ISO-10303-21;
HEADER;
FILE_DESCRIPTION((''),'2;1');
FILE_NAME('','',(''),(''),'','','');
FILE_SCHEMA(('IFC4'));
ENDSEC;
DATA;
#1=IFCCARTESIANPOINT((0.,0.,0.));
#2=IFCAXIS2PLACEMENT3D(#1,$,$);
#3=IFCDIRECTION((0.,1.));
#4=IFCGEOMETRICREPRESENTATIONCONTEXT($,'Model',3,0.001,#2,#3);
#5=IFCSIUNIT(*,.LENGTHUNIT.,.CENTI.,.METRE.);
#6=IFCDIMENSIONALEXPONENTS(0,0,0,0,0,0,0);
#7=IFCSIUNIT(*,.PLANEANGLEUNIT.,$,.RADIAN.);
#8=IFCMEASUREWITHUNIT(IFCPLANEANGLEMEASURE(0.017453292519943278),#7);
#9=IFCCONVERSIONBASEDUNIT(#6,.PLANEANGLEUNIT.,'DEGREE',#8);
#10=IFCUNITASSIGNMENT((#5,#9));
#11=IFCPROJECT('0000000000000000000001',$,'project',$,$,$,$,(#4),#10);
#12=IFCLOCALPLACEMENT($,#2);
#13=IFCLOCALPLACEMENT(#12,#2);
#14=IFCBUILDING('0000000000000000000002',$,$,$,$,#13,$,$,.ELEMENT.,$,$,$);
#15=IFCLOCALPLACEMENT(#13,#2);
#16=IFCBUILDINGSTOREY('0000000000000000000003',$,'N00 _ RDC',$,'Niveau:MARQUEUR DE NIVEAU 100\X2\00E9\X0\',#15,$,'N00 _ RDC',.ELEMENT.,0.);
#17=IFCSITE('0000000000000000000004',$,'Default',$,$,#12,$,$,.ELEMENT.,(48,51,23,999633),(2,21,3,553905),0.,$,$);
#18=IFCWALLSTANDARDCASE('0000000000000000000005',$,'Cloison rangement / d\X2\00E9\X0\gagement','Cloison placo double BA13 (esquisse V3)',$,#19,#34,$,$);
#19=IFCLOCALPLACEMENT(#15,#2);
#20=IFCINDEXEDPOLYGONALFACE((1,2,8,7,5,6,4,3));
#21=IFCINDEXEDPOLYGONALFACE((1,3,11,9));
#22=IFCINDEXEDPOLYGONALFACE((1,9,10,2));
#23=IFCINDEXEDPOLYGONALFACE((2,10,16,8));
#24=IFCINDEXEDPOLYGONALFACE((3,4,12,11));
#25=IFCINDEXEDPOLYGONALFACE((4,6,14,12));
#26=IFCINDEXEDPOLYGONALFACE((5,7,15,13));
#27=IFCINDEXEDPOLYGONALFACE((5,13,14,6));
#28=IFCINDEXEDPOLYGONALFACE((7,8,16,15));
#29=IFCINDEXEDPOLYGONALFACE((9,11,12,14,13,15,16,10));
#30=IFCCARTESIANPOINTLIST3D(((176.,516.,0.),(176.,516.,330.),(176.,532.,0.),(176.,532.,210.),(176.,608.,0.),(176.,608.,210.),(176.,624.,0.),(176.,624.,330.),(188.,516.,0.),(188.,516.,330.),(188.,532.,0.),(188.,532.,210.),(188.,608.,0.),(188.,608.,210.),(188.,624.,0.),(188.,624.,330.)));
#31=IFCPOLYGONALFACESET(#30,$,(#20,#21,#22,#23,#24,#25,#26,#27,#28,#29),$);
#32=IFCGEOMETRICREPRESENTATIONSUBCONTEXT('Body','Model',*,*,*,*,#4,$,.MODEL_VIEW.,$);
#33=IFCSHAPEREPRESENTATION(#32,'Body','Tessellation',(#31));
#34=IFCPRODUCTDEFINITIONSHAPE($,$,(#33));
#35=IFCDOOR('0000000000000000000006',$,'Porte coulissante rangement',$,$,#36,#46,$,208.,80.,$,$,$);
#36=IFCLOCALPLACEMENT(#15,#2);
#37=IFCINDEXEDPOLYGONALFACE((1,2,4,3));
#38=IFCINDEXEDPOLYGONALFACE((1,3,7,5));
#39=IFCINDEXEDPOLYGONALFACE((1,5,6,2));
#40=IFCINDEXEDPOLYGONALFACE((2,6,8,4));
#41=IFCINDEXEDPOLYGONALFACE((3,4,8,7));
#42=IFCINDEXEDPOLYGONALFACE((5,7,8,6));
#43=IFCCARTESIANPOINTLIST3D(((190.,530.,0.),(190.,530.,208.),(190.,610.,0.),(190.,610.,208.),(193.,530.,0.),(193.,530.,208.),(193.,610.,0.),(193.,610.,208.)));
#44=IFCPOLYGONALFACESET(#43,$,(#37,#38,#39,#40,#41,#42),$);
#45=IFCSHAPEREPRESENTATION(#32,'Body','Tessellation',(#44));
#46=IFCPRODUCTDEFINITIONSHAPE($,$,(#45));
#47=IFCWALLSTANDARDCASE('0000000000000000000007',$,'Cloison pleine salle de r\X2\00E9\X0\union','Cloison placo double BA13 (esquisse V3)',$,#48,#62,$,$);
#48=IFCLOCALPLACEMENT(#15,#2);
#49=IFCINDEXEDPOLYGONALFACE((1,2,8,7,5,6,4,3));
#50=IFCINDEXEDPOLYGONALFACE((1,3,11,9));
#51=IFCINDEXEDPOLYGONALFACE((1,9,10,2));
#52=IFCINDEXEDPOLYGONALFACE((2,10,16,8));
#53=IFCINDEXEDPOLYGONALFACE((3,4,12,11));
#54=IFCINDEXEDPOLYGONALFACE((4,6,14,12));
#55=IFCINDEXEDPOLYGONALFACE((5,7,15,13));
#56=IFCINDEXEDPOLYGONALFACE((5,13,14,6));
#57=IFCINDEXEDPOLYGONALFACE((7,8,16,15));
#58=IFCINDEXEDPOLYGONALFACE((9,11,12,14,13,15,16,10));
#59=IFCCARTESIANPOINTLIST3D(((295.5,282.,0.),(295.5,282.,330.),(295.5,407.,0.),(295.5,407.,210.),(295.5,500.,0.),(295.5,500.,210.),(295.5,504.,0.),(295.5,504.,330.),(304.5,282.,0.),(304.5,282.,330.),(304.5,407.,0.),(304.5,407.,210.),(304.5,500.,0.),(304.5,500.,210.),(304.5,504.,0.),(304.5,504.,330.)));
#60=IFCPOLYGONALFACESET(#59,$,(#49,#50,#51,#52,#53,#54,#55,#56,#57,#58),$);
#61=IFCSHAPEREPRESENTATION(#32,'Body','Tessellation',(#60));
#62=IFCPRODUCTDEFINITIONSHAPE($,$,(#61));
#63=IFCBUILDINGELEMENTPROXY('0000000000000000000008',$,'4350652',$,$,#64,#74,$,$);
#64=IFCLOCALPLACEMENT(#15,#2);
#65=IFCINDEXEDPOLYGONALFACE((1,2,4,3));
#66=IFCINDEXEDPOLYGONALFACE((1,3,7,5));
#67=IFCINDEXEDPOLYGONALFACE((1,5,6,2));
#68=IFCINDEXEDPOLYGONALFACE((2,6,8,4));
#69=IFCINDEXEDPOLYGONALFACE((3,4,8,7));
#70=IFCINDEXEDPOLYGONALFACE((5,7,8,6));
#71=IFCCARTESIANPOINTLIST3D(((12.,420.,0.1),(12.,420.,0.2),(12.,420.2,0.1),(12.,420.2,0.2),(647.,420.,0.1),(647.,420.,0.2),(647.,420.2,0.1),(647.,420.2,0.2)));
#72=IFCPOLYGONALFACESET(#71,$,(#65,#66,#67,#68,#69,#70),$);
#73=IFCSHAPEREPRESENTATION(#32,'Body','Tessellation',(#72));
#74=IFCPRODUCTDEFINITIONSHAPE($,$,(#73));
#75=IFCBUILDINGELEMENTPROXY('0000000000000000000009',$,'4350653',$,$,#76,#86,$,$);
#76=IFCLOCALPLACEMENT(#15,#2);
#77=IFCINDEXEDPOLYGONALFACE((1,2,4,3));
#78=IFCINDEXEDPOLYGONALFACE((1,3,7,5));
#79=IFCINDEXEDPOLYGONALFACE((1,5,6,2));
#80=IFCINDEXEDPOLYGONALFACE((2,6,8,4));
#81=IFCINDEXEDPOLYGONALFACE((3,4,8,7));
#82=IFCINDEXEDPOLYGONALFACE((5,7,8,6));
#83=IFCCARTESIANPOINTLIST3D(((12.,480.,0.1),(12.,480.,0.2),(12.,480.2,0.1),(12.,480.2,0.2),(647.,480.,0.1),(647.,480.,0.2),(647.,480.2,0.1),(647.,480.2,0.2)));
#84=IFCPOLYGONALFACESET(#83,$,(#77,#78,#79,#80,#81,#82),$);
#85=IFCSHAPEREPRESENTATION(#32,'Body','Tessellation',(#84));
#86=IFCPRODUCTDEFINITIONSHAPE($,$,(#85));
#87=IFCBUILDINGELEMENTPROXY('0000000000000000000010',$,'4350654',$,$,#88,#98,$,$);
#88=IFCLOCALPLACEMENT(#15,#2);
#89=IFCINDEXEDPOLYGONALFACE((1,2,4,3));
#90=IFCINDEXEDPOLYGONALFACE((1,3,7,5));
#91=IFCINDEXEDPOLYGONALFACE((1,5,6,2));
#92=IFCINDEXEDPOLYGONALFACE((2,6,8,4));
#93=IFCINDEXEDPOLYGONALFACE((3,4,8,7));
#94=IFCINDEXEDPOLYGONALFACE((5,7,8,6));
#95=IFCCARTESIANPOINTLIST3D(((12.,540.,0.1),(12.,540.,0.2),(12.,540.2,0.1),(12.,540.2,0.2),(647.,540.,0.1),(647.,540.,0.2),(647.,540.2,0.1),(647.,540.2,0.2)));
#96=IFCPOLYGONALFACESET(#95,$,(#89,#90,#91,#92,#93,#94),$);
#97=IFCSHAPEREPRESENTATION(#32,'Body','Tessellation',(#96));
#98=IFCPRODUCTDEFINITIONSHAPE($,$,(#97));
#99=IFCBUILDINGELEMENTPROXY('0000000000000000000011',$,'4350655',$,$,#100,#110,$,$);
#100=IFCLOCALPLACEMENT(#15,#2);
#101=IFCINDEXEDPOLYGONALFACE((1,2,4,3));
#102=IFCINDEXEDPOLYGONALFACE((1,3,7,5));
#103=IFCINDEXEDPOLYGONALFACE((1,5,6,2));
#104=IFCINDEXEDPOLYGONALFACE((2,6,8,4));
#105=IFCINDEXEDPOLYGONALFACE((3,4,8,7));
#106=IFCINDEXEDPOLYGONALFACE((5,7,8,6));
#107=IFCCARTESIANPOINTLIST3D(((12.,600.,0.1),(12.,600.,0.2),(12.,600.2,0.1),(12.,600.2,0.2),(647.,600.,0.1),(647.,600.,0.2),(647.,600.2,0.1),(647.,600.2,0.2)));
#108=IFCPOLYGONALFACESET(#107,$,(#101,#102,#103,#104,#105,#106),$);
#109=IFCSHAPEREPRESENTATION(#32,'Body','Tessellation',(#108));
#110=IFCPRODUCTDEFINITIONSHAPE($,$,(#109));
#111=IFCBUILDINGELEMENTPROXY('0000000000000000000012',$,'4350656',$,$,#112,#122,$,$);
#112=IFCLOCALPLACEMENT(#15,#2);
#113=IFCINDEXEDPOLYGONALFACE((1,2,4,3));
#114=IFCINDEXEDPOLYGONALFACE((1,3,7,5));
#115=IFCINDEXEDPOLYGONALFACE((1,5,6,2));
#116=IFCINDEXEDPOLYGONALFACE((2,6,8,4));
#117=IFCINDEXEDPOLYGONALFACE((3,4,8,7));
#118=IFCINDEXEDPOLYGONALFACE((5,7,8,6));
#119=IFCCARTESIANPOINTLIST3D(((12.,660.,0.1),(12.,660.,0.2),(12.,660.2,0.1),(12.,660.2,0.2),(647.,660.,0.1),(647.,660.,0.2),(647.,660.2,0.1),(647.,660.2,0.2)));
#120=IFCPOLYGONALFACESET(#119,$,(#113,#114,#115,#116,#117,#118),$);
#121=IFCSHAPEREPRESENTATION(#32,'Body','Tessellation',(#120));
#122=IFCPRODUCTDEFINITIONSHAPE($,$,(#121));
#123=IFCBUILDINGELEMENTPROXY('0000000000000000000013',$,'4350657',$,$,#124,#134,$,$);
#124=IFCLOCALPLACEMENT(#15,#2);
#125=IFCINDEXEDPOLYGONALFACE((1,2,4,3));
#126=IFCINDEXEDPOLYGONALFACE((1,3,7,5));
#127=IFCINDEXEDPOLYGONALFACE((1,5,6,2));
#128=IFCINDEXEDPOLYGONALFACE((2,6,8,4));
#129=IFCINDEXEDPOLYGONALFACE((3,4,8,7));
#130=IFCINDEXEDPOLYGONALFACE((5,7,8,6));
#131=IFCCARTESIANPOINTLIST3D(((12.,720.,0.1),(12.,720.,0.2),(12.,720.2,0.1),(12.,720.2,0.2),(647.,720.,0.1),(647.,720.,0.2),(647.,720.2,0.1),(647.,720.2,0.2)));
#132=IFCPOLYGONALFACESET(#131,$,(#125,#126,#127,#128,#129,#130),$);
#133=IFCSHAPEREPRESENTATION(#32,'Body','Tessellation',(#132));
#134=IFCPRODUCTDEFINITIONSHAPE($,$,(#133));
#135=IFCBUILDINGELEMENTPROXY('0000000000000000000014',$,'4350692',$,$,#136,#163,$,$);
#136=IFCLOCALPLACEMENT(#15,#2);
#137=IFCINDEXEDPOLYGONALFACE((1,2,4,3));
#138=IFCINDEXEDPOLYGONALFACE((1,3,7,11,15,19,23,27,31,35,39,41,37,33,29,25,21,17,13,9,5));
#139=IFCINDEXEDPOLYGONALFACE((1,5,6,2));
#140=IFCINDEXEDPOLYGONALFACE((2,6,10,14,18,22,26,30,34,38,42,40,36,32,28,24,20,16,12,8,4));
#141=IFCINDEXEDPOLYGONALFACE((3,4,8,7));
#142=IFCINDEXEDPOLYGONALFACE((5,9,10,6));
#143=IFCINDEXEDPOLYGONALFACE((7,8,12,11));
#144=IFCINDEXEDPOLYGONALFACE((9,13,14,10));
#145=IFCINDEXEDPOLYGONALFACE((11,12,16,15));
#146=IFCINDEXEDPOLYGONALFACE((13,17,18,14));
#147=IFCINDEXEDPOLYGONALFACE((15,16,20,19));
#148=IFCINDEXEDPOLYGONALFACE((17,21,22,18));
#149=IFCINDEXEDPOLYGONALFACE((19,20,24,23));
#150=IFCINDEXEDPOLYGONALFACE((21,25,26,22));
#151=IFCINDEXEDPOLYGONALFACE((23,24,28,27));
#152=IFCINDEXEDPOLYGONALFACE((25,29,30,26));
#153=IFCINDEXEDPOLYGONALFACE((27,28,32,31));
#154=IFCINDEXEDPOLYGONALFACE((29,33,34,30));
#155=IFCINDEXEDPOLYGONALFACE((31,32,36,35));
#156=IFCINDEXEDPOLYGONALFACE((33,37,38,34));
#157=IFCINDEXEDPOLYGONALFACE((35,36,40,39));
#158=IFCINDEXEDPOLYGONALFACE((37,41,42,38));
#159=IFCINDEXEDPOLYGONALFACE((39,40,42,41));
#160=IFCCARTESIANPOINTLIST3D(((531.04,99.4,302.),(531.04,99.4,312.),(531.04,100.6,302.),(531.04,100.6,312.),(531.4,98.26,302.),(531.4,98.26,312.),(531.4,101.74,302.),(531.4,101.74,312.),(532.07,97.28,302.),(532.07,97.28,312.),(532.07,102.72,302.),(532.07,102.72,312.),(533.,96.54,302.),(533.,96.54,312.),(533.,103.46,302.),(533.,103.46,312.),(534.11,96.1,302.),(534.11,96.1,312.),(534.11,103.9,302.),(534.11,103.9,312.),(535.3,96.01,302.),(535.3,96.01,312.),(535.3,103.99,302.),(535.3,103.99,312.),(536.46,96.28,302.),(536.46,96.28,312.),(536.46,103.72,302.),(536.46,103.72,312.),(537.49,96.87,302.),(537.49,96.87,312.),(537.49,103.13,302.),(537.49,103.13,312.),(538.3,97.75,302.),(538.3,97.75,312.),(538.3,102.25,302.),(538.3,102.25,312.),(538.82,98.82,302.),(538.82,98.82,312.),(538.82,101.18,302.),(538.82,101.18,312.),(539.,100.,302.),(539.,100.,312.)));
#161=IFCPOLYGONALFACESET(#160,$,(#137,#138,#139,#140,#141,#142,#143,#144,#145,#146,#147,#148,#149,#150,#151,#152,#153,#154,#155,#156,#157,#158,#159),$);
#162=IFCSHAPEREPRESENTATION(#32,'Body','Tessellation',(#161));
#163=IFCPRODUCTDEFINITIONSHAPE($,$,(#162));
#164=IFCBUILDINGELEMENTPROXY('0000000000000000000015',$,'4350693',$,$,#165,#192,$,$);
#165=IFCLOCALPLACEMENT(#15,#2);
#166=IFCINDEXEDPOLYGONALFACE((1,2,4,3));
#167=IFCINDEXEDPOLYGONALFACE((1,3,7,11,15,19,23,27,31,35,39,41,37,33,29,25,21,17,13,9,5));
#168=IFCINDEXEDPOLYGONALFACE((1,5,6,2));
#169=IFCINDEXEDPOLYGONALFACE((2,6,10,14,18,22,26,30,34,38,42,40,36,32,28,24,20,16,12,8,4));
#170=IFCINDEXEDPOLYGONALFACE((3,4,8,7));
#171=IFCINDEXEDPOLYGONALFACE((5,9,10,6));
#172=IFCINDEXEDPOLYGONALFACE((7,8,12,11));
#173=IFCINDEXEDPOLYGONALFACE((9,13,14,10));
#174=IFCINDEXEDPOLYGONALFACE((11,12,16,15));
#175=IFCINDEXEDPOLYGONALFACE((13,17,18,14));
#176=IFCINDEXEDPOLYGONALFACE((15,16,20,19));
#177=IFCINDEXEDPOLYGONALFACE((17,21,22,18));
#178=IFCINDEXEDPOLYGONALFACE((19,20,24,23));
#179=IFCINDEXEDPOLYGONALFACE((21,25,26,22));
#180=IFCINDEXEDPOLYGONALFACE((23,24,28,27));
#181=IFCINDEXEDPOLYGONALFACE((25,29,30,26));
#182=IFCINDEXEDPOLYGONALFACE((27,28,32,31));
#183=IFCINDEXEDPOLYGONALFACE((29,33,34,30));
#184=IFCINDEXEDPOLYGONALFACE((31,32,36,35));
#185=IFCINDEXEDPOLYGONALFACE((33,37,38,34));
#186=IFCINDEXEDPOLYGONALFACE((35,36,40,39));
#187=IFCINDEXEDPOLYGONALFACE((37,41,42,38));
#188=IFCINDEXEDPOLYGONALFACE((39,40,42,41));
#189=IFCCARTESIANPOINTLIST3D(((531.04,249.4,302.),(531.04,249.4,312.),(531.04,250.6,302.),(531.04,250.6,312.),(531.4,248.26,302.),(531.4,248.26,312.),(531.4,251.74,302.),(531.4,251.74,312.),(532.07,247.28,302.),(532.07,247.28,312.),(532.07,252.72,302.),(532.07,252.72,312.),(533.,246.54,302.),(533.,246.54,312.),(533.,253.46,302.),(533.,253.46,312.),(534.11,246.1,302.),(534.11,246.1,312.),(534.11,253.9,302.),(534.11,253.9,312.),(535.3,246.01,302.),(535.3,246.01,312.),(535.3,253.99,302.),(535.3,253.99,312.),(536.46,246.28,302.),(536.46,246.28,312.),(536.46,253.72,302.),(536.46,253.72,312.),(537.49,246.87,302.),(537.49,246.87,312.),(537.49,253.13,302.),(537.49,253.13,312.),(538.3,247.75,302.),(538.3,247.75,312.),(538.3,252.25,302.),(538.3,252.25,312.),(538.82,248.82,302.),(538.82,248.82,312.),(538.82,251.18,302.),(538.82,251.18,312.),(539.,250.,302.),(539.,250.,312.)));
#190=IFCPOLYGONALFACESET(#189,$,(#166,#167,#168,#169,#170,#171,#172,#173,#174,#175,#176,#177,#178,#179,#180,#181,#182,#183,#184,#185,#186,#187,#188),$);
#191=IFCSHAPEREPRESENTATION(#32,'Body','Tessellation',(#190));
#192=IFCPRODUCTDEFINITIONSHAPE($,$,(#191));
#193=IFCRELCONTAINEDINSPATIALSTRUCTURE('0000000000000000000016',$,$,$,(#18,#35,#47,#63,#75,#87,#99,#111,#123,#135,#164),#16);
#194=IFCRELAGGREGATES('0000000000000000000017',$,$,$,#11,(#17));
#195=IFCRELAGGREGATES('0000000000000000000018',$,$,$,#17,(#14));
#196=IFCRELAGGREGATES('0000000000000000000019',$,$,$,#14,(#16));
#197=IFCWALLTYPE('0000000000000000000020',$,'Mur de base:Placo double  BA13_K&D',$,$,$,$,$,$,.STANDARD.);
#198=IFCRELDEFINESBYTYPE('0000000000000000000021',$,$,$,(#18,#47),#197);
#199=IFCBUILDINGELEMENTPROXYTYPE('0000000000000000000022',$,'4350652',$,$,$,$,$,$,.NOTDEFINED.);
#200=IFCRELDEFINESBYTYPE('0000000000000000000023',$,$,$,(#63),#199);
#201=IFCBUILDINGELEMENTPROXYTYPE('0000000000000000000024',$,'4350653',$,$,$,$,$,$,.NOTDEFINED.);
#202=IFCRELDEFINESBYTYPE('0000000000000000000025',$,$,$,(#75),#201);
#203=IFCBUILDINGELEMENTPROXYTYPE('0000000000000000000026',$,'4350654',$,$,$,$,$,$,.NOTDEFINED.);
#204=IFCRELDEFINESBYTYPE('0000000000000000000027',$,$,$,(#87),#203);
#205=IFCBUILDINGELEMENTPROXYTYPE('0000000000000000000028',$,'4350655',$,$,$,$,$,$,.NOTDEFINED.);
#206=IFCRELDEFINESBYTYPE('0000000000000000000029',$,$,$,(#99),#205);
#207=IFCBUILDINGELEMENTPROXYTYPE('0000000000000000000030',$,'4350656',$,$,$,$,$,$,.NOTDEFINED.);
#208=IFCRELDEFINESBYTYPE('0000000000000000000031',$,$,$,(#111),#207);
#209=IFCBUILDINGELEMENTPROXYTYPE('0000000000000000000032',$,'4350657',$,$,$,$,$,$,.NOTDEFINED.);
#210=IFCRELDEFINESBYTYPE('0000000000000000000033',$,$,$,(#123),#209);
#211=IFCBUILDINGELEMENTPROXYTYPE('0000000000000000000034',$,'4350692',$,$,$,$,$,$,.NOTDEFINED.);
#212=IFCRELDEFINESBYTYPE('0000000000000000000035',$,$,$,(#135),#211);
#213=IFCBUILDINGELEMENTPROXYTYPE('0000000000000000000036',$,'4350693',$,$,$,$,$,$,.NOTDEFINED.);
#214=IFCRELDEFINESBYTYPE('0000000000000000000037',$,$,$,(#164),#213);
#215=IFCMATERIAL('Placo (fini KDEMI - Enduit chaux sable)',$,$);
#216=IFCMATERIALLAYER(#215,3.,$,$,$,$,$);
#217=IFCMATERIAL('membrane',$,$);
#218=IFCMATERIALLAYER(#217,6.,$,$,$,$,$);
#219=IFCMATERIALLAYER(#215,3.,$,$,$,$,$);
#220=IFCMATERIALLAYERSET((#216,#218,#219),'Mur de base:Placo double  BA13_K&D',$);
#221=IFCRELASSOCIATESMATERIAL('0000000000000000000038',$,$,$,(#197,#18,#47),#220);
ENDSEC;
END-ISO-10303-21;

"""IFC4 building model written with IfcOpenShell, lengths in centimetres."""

from ifc_helpers import new_model, entity, si_unit, converted_unit, direction, frame, frame_2d, origin, origin_with_axes, origin_2d_with_axis, place, context, subcontext, project, spatial, rectangle, circle, extrude, material, layer, layer_set, layer_usage, type_object, element, fill, save


model = new_model("IFC4")

# Units and contexts
model_context = context("Model", 3, precision=0.001, world=origin(), true_north=direction((0.0, 1.0)))
body_context = subcontext(model_context, "Body", "Model", "MODEL_VIEW")
ifc_project = project(units=[si_unit("LENGTHUNIT", "METRE", prefix="CENTI"), converted_unit("PLANEANGLEUNIT", "DEGREE", entity("IfcPlaneAngleMeasure", 0.017453292519943278), si_unit("PLANEANGLEUNIT", "RADIAN"), dimensions=[0, 0, 0, 0, 0, 0, 0])], contexts=[model_context])

# Site, building, storey
site_placement = place(None, origin())
site = spatial("IfcSite", under=ifc_project, at=site_placement, Name="Default", CompositionType="ELEMENT", RefLatitude=(48, 51, 23, 999633), RefLongitude=(2, 21, 3, 553905), RefElevation=0.0)
building_placement = place(site_placement, origin())
building = spatial("IfcBuilding", under=site, at=building_placement, CompositionType="ELEMENT")
storey_placement = place(building_placement, origin())
storey = spatial("IfcBuildingStorey", under=building, at=storey_placement, Name="N00 _ RDC", ObjectType="Niveau:MARQUEUR DE NIVEAU 100é", LongName="N00 _ RDC", CompositionType="ELEMENT", Elevation=0.0)

# Wall, opening, door
ifc_material_1 = material(Name="Placo (fini KDEMI - Enduit chaux sable)")
ifc_layer_1 = layer(ifc_material_1, 3.0)
ifc_material_2 = material(Name="membrane")
ifc_layer_2 = layer(ifc_material_2, 6.0)
ifc_layer_3 = layer(ifc_material_1, 3.0)
ifc_layer_set = layer_set([ifc_layer_1, ifc_layer_2, ifc_layer_3], Name="Mur de base:Placo double  BA13_K&D")
ifc_layer_usage_1 = layer_usage(ifc_layer_set, "AXIS2", "POSITIVE", 0.0)
wall_type = type_object("IfcWallType", Name="Mur de base:Placo double  BA13_K&D", PredefinedType="STANDARD", material=ifc_layer_set)
wall_1_placement = place(storey_placement, origin_with_axes())
wall_1 = element("IfcWallStandardCase", 1, at=wall_1_placement, inside=storey, type_object=wall_type, material=ifc_layer_usage_1, Name="Cloison rangement / dégagement", Description="Cloison placo double BA13 (esquisse V3)", context=body_context, shape_type="SweptSolid", body=[
    extrude(rectangle(XDim=12.0, YDim=108.0, at=frame_2d((182.0, 570.0))), origin(), (0.0, 0.0, 1.0), 330.0),
])
opening_1_placement = place(wall_1_placement, origin_with_axes())
opening_1 = element("IfcOpeningElement", 2, at=opening_1_placement, inside=storey, cuts=wall_1, context=body_context, shape_type="SweptSolid", body=[
    extrude(rectangle(XDim=16.0, YDim=76.0, at=frame_2d((182.0, 570.0))), origin(), (0.0, 0.0, 1.0), 210.0),
])
door_placement = place(storey_placement, origin_with_axes())
door = element("IfcDoor", 3, at=door_placement, inside=storey, Name="Porte coulissante rangement", OverallHeight=208.0, OverallWidth=80.0, context=body_context, shape_type="SweptSolid", body=[
    extrude(rectangle(XDim=3.0, YDim=80.0, at=frame_2d((191.5, 570.0))), origin(), (0.0, 0.0, 1.0), 208.0),
])
fill(opening_1, door)

# Wall, opening
ifc_layer_usage_2 = layer_usage(ifc_layer_set, "AXIS2", "POSITIVE", 0.0)
wall_2_placement = place(storey_placement, origin_with_axes())
wall_2 = element("IfcWallStandardCase", 4, at=wall_2_placement, inside=storey, type_object=wall_type, material=ifc_layer_usage_2, Name="Cloison pleine salle de réunion", Description="Cloison placo double BA13 (esquisse V3)", context=body_context, shape_type="SweptSolid", body=[
    extrude(rectangle(XDim=9.0, YDim=222.0, at=frame_2d((300.0, 393.0))), origin(), (0.0, 0.0, 1.0), 330.0),
])
opening_2_placement = place(wall_2_placement, origin_with_axes())
element("IfcOpeningElement", 5, at=opening_2_placement, inside=storey, cuts=wall_2, context=body_context, shape_type="SweptSolid", body=[
    extrude(rectangle(XDim=12.0, YDim=93.0, at=frame_2d((300.0, 453.5))), origin(), (0.0, 0.0, 1.0), 210.0),
])

# Building element proxies
building_element_proxy_type_1 = type_object("IfcBuildingElementProxyType", Name="4350652", PredefinedType="NOTDEFINED")
proxy_1_placement = place(storey_placement, origin())
element("IfcBuildingElementProxy", 6, at=proxy_1_placement, inside=storey, type_object=building_element_proxy_type_1, Name="4350652", context=body_context, shape_type="SweptSolid", body=[
    extrude(rectangle(XDim=635.0, YDim=0.2, at=frame_2d((0.0, 0.0), x_axis=(1.0, 0.0))), frame((329.5, 420.1, 0.1)), (0.0, 0.0, 1.0), 0.1),
])
building_element_proxy_type_2 = type_object("IfcBuildingElementProxyType", Name="4350653", PredefinedType="NOTDEFINED")
proxy_2_placement = place(storey_placement, origin())
element("IfcBuildingElementProxy", 7, at=proxy_2_placement, inside=storey, type_object=building_element_proxy_type_2, Name="4350653", context=body_context, shape_type="SweptSolid", body=[
    extrude(rectangle(XDim=635.0, YDim=0.2, at=frame_2d((0.0, 0.0), x_axis=(1.0, 0.0))), frame((329.5, 480.1, 0.1)), (0.0, 0.0, 1.0), 0.1),
])
building_element_proxy_type_3 = type_object("IfcBuildingElementProxyType", Name="4350654", PredefinedType="NOTDEFINED")
proxy_3_placement = place(storey_placement, origin())
element("IfcBuildingElementProxy", 8, at=proxy_3_placement, inside=storey, type_object=building_element_proxy_type_3, Name="4350654", context=body_context, shape_type="SweptSolid", body=[
    extrude(rectangle(XDim=635.0, YDim=0.2, at=frame_2d((0.0, 0.0), x_axis=(1.0, 0.0))), frame((329.5, 540.1, 0.1)), (0.0, 0.0, 1.0), 0.1),
])
building_element_proxy_type_4 = type_object("IfcBuildingElementProxyType", Name="4350655", PredefinedType="NOTDEFINED")
proxy_4_placement = place(storey_placement, origin())
element("IfcBuildingElementProxy", 9, at=proxy_4_placement, inside=storey, type_object=building_element_proxy_type_4, Name="4350655", context=body_context, shape_type="SweptSolid", body=[
    extrude(rectangle(XDim=635.0, YDim=0.2, at=frame_2d((0.0, 0.0), x_axis=(1.0, 0.0))), frame((329.5, 600.1, 0.1)), (0.0, 0.0, 1.0), 0.1),
])
building_element_proxy_type_5 = type_object("IfcBuildingElementProxyType", Name="4350656", PredefinedType="NOTDEFINED")
proxy_5_placement = place(storey_placement, origin())
element("IfcBuildingElementProxy", 10, at=proxy_5_placement, inside=storey, type_object=building_element_proxy_type_5, Name="4350656", context=body_context, shape_type="SweptSolid", body=[
    extrude(rectangle(XDim=635.0, YDim=0.2, at=frame_2d((0.0, 0.0), x_axis=(1.0, 0.0))), frame((329.5, 660.1, 0.1)), (0.0, 0.0, 1.0), 0.1),
])
building_element_proxy_type_6 = type_object("IfcBuildingElementProxyType", Name="4350657", PredefinedType="NOTDEFINED")
proxy_6_placement = place(storey_placement, origin())
element("IfcBuildingElementProxy", 11, at=proxy_6_placement, inside=storey, type_object=building_element_proxy_type_6, Name="4350657", context=body_context, shape_type="SweptSolid", body=[
    extrude(rectangle(XDim=635.0, YDim=0.2, at=frame_2d((0.0, 0.0), x_axis=(1.0, 0.0))), frame((329.5, 720.1, 0.1)), (0.0, 0.0, 1.0), 0.1),
])
building_element_proxy_type_7 = type_object("IfcBuildingElementProxyType", Name="4350692", PredefinedType="NOTDEFINED")
proxy_7_placement = place(storey_placement, origin())
element("IfcBuildingElementProxy", 12, at=proxy_7_placement, inside=storey, type_object=building_element_proxy_type_7, Name="4350692", context=body_context, shape_type="SweptSolid", body=[
    extrude(circle(Radius=4.0, at=origin_2d_with_axis()), frame((535.0, 100.0, 302.0)), (0.0, 0.0, 1.0), 10.0),
])
building_element_proxy_type_8 = type_object("IfcBuildingElementProxyType", Name="4350693", PredefinedType="NOTDEFINED")
proxy_8_placement = place(storey_placement, origin())
element("IfcBuildingElementProxy", 13, at=proxy_8_placement, inside=storey, type_object=building_element_proxy_type_8, Name="4350693", context=body_context, shape_type="SweptSolid", body=[
    extrude(circle(Radius=4.0, at=origin_2d_with_axis()), frame((535.0, 250.0, 302.0)), (0.0, 0.0, 1.0), 10.0),
])

save(model, "model.ifc")
